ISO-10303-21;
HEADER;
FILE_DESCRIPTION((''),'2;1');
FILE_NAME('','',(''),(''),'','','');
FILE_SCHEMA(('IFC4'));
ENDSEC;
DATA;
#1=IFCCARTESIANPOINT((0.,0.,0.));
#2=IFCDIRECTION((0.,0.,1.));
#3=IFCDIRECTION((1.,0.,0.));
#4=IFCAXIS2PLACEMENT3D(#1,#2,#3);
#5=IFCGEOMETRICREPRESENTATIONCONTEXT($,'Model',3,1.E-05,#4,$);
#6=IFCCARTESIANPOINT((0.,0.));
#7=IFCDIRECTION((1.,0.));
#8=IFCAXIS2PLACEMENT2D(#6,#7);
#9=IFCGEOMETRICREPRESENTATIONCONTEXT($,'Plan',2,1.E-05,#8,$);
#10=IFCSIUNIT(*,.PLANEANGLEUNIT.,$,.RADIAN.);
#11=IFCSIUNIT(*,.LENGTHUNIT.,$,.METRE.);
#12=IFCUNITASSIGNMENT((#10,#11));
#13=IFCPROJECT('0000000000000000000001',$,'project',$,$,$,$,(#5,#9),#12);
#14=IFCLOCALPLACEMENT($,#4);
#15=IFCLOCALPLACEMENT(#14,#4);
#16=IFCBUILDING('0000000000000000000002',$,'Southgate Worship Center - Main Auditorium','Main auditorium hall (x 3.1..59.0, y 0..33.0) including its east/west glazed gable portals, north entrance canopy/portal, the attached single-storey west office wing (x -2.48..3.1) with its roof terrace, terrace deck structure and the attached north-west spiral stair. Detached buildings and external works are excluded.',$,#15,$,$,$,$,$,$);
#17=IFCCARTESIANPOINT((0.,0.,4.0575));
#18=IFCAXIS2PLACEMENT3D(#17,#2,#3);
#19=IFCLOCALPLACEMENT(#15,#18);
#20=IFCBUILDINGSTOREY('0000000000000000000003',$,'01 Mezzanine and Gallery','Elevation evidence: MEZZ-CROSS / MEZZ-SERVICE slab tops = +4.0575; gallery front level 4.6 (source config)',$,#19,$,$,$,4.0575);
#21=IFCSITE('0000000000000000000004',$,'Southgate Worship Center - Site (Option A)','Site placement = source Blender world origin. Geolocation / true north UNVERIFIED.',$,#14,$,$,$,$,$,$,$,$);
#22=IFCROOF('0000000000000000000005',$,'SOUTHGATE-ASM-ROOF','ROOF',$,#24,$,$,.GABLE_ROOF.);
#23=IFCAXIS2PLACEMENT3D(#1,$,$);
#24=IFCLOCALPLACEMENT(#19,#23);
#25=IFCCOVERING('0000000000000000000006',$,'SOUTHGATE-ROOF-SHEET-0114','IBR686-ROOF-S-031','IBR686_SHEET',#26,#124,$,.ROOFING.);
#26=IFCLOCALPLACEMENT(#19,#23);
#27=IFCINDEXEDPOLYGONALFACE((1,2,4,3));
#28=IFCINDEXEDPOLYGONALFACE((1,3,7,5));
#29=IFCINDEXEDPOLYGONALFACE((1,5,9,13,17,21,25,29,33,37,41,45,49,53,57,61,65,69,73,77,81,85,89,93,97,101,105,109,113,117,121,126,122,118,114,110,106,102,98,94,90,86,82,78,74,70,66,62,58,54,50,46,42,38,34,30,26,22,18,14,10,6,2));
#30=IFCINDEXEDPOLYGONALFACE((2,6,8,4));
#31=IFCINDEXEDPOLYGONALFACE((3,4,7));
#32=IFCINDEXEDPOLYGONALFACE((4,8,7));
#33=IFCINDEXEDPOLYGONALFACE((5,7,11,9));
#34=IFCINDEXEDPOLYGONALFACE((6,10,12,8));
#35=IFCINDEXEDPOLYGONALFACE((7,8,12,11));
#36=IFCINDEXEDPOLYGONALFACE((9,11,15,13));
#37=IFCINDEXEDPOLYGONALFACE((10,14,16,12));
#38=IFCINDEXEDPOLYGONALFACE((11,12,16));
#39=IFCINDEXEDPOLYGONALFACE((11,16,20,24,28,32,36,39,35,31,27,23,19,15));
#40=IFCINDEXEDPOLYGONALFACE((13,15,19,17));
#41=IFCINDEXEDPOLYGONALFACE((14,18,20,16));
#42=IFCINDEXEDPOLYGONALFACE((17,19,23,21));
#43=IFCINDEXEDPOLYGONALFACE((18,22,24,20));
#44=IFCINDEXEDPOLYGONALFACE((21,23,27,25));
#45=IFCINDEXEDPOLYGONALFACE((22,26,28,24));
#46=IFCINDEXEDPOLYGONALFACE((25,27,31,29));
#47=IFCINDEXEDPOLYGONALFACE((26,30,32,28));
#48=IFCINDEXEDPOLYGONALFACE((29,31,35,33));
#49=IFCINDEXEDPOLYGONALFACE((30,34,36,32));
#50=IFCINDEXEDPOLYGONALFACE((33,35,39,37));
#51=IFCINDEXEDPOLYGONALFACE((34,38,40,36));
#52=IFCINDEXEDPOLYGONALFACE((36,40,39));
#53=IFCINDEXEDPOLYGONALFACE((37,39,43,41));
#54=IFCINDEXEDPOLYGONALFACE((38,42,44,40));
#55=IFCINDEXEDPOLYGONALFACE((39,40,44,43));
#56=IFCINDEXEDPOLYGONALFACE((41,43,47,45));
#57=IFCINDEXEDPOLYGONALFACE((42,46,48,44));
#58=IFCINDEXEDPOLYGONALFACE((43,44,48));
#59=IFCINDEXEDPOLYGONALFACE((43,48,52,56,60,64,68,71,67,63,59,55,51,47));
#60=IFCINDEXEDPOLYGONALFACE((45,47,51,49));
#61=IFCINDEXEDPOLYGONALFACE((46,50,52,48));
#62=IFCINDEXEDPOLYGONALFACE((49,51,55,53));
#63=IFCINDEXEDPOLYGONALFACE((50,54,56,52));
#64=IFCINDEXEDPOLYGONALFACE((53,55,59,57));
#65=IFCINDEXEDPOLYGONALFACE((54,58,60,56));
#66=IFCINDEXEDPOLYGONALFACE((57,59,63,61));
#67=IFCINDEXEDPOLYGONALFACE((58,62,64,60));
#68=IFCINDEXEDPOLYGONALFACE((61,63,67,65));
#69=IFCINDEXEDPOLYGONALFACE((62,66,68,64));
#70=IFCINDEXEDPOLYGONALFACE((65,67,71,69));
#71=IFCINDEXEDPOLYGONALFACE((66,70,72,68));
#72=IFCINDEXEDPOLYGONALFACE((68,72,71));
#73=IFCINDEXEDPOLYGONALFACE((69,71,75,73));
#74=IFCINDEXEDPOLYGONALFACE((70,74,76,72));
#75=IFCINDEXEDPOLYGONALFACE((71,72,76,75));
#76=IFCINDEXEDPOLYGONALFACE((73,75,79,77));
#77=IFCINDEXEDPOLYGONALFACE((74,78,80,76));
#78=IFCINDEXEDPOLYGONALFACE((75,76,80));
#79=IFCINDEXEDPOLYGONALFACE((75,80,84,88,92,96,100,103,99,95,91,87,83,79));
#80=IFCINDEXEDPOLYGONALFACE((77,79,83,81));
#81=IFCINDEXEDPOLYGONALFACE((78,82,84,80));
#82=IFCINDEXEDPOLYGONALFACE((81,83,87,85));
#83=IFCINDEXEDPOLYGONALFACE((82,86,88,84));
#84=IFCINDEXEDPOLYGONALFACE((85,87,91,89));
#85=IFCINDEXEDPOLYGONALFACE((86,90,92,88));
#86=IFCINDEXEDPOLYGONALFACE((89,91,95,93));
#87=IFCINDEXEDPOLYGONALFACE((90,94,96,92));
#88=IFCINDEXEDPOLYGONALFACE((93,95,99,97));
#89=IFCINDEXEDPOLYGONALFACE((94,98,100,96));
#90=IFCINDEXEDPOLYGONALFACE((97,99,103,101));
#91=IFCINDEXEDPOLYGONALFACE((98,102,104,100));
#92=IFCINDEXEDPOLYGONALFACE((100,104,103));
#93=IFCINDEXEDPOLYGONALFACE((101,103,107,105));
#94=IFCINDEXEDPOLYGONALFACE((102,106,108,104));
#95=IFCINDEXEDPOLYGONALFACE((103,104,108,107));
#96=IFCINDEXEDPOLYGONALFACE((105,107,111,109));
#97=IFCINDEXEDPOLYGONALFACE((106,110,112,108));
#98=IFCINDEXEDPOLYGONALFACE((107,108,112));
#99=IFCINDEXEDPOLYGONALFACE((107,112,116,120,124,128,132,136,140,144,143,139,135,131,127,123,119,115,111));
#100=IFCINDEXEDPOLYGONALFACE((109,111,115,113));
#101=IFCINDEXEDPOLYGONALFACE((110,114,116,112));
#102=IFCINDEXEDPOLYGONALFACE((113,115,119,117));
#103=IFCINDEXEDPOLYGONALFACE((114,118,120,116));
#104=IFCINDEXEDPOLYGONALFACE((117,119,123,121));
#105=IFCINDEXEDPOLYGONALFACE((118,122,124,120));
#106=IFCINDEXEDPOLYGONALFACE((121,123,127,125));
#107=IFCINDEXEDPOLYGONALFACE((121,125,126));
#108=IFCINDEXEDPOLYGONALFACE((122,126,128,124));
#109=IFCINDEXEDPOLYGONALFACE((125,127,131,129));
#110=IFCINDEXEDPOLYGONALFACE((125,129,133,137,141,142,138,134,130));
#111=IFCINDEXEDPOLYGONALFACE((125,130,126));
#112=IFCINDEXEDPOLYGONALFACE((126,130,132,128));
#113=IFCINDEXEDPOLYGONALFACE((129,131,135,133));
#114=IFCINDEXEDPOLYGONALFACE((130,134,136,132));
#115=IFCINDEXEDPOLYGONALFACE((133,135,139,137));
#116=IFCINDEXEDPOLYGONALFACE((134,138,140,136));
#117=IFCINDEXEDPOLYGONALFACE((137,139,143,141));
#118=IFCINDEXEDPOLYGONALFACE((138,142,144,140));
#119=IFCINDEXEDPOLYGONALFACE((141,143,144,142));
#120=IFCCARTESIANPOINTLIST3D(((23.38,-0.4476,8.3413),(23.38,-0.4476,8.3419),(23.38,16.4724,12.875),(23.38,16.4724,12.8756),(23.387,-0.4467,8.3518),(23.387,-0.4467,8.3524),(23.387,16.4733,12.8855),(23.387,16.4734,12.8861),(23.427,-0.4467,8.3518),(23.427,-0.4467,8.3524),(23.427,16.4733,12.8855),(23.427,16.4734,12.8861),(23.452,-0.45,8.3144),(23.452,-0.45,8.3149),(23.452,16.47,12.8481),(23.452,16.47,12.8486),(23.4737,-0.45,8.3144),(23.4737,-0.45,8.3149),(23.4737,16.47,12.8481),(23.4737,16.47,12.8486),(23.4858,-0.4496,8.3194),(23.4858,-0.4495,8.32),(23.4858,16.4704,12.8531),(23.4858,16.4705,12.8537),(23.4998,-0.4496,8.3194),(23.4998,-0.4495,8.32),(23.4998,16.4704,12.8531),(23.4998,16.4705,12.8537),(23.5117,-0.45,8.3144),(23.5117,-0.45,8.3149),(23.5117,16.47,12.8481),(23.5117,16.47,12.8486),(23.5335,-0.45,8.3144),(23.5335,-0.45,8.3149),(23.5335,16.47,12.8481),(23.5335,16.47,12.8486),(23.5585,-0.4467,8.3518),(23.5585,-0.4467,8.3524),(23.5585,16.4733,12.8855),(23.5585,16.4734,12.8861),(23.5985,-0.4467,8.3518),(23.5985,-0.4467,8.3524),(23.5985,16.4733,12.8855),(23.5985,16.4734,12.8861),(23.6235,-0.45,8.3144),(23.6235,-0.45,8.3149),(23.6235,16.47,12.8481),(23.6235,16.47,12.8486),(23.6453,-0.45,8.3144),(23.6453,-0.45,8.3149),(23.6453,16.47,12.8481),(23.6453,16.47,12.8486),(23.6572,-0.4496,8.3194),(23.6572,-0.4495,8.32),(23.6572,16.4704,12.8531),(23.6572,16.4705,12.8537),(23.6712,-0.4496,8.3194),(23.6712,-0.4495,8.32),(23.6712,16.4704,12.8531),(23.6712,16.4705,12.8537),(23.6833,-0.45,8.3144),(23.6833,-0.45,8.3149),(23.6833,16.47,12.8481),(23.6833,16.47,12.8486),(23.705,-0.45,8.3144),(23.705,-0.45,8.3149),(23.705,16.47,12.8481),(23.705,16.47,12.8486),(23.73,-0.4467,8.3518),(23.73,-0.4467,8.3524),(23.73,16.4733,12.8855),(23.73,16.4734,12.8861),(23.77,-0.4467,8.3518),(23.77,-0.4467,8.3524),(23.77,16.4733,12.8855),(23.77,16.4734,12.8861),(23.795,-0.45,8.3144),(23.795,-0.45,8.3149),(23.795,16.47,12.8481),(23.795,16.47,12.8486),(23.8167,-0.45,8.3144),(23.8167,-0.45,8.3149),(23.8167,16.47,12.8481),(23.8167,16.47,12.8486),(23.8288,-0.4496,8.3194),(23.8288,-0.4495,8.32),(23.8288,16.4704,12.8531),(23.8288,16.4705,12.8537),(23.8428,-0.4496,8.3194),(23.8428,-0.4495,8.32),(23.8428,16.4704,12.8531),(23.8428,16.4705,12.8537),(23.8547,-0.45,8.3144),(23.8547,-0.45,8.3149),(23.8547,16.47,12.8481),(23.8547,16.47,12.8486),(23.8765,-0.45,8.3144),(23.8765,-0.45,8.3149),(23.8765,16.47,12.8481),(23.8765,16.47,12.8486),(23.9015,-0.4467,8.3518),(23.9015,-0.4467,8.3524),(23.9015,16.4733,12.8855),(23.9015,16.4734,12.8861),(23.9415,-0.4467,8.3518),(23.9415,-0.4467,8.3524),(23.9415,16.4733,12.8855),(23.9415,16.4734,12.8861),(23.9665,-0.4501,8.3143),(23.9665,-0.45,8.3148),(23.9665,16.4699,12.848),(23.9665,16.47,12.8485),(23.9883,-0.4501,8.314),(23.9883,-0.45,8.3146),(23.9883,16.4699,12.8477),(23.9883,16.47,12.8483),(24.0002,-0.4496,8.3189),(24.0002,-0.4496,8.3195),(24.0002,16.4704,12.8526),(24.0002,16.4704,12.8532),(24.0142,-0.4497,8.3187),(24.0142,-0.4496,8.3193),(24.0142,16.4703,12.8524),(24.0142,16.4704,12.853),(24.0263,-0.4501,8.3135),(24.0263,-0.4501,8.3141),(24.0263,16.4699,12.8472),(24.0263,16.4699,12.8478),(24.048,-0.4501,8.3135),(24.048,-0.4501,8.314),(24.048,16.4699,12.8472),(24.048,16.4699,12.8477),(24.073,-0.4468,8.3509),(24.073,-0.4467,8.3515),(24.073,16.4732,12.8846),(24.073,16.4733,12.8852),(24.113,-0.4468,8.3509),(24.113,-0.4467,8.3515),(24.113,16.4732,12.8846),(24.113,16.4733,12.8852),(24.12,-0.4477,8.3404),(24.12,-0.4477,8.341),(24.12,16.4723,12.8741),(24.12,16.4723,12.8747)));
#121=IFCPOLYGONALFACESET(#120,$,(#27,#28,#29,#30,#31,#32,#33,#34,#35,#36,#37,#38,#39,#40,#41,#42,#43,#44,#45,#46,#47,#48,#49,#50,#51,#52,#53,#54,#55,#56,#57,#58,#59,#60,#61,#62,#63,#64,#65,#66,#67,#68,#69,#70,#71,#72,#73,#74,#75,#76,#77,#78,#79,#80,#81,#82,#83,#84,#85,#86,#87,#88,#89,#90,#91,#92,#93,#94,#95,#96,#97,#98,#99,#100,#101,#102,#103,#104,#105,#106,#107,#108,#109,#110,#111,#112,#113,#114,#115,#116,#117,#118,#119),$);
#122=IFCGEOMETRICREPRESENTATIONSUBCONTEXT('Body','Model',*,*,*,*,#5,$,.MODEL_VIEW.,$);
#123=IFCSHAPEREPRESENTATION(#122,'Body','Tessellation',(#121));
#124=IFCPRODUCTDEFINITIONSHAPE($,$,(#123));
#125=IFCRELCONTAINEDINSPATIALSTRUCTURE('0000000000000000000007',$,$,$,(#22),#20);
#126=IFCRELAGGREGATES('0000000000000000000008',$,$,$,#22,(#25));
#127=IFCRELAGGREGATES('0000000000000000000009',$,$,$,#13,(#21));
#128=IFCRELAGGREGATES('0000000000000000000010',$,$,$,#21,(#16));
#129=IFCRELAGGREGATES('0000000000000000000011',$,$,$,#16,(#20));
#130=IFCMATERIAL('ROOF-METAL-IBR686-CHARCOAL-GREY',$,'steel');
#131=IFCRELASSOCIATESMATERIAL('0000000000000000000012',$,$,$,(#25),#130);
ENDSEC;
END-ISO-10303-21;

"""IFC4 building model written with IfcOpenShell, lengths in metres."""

from ifc_helpers import new_model, si_unit, frame, origin_with_axes, origin_2d_with_axis, place, context, subcontext, project, spatial, indexed_curve, outline, extrude, clip, halfspace, material, element, aggregate, save


model = new_model("IFC4")

# Units and contexts
model_context = context("Model", 3, precision=1e-05, world=origin_with_axes())
plan_context = context("Plan", 2, precision=1e-05, world=origin_2d_with_axis())
body_context = subcontext(model_context, "Body", "Model", "MODEL_VIEW")
ifc_project = project(units=[si_unit("PLANEANGLEUNIT", "RADIAN"), si_unit("LENGTHUNIT", "METRE")], contexts=[model_context, plan_context])

# Site, building, storey
site_placement = place(None, origin_with_axes())
site = spatial("IfcSite", under=ifc_project, at=site_placement, Name="Southgate Worship Center - Site (Option A)", Description="Site placement = source Blender world origin. Geolocation / true north UNVERIFIED.")
building_placement = place(site_placement, origin_with_axes())
building = spatial("IfcBuilding", under=site, at=building_placement, Name="Southgate Worship Center - Main Auditorium", Description="Main auditorium hall (x 3.1..59.0, y 0..33.0) including its east/west glazed gable portals, north entrance canopy/portal, the attached single-storey west office wing (x -2.48..3.1) with its roof terrace, terrace deck structure and the attached north-west spiral stair. Detached buildings and external works are excluded.")
storey_placement = place(building_placement, frame((0.0, 0.0, 4.0575), z_axis=(0.0, 0.0, 1.0), x_axis=(1.0, 0.0, 0.0)))
storey = spatial("IfcBuildingStorey", under=building, at=storey_placement, Name="01 Mezzanine and Gallery", Description="Elevation evidence: MEZZ-CROSS / MEZZ-SERVICE slab tops = +4.0575; gallery front level 4.6 (source config)", Elevation=4.0575)

# Roof, covering
roof_placement = place(storey_placement, origin_with_axes())
roof = element("IfcRoof", 1, at=roof_placement, inside=storey, Name="SOUTHGATE-ASM-ROOF", Description="ROOF", PredefinedType="GABLE_ROOF")
ifc_material_1 = material(Name="ROOF-METAL-IBR686-CHARCOAL-GREY", Category="steel")
covering_1_placement = place(roof_placement, frame((23.38, -0.4501, 8.3135), z_axis=(0.0, 0.0, 1.0), x_axis=(1.0, 0.0, 0.0)))
covering_1 = element("IfcCovering", 2, at=covering_1_placement, material=ifc_material_1, Name="SOUTHGATE-ROOF-SHEET-0114", Description="IBR686-ROOF-S-031", ObjectType="IBR686_SHEET", PredefinedType="ROOFING", context=body_context, shape_type="Clipping", body=[
    clip(clip(extrude(outline(indexed_curve([(0.0, 0.0), (0.025, 0.0353), (0.065, 0.0353), (0.072, 0.0254), (0.072, 0.0259), (0.065, 0.0358), (0.025, 0.0358), (0.0, 0.0005), (-0.0217, 0.0005), (-0.0338, 0.0053), (-0.0478, 0.0053), (-0.0597, 0.0005), (-0.0815, 0.0005), (-0.1065, 0.0358), (-0.1465, 0.0358), (-0.1715, 0.0005), (-0.1933, 0.0005), (-0.2052, 0.0053), (-0.2192, 0.0053), (-0.2313, 0.0005), (-0.253, 0.0005), (-0.278, 0.0358), (-0.318, 0.0358), (-0.343, 0.0005), (-0.3647, 0.0005), (-0.3768, 0.0053), (-0.3908, 0.0053), (-0.4028, 0.0005), (-0.4245, 0.0005), (-0.4495, 0.0358), (-0.4895, 0.0358), (-0.5145, 0.0004), (-0.5363, 0.0002), (-0.5483, 0.0048), (-0.5623, 0.0046), (-0.5743, -0.0003), (-0.596, -0.0004), (-0.621, 0.0349), (-0.661, 0.0349), (-0.668, 0.0251), (-0.668, 0.0246), (-0.661, 0.0344), (-0.621, 0.0344), (-0.596, -0.0009), (-0.5743, -0.0008), (-0.5623, 0.0041), (-0.5483, 0.0043), (-0.5363, -0.0003), (-0.5145, -0.0001), (-0.4895, 0.0353), (-0.4495, 0.0353), (-0.4245, 0.0), (-0.4028, 0.0), (-0.3908, 0.0048), (-0.3768, 0.0048), (-0.3647, 0.0), (-0.343, 0.0), (-0.318, 0.0353), (-0.278, 0.0353), (-0.253, 0.0), (-0.2313, 0.0), (-0.2192, 0.0048), (-0.2052, 0.0048), (-0.1933, 0.0), (-0.1715, 0.0), (-0.1465, 0.0353), (-0.1065, 0.0353), (-0.0815, 0.0), (-0.0597, 0.0), (-0.0478, 0.0048), (-0.0338, 0.0048), (-0.0217, 0.0), (0.0, 0.0)], self_intersect=False)), frame((0.072, -0.0003, 0.0008), z_axis=(0.0, 0.965926, 0.258819), x_axis=(-1.0, 0.0, 0.0)), (0.0, 0.0, 1.0), 17.5303), halfspace(frame((0.37, 0.0012, 0.014), z_axis=(0.0, -0.996022, 0.089113), x_axis=(1.0, 0.0, 0.0)), False)), halfspace(frame((0.37, 16.9212, 4.5477), z_axis=(0.0, 0.996021, -0.089119), x_axis=(-1.0, 0.0, 0.0)), False)),
])
aggregate(roof, [covering_1])

save(model, "model.ifc")
